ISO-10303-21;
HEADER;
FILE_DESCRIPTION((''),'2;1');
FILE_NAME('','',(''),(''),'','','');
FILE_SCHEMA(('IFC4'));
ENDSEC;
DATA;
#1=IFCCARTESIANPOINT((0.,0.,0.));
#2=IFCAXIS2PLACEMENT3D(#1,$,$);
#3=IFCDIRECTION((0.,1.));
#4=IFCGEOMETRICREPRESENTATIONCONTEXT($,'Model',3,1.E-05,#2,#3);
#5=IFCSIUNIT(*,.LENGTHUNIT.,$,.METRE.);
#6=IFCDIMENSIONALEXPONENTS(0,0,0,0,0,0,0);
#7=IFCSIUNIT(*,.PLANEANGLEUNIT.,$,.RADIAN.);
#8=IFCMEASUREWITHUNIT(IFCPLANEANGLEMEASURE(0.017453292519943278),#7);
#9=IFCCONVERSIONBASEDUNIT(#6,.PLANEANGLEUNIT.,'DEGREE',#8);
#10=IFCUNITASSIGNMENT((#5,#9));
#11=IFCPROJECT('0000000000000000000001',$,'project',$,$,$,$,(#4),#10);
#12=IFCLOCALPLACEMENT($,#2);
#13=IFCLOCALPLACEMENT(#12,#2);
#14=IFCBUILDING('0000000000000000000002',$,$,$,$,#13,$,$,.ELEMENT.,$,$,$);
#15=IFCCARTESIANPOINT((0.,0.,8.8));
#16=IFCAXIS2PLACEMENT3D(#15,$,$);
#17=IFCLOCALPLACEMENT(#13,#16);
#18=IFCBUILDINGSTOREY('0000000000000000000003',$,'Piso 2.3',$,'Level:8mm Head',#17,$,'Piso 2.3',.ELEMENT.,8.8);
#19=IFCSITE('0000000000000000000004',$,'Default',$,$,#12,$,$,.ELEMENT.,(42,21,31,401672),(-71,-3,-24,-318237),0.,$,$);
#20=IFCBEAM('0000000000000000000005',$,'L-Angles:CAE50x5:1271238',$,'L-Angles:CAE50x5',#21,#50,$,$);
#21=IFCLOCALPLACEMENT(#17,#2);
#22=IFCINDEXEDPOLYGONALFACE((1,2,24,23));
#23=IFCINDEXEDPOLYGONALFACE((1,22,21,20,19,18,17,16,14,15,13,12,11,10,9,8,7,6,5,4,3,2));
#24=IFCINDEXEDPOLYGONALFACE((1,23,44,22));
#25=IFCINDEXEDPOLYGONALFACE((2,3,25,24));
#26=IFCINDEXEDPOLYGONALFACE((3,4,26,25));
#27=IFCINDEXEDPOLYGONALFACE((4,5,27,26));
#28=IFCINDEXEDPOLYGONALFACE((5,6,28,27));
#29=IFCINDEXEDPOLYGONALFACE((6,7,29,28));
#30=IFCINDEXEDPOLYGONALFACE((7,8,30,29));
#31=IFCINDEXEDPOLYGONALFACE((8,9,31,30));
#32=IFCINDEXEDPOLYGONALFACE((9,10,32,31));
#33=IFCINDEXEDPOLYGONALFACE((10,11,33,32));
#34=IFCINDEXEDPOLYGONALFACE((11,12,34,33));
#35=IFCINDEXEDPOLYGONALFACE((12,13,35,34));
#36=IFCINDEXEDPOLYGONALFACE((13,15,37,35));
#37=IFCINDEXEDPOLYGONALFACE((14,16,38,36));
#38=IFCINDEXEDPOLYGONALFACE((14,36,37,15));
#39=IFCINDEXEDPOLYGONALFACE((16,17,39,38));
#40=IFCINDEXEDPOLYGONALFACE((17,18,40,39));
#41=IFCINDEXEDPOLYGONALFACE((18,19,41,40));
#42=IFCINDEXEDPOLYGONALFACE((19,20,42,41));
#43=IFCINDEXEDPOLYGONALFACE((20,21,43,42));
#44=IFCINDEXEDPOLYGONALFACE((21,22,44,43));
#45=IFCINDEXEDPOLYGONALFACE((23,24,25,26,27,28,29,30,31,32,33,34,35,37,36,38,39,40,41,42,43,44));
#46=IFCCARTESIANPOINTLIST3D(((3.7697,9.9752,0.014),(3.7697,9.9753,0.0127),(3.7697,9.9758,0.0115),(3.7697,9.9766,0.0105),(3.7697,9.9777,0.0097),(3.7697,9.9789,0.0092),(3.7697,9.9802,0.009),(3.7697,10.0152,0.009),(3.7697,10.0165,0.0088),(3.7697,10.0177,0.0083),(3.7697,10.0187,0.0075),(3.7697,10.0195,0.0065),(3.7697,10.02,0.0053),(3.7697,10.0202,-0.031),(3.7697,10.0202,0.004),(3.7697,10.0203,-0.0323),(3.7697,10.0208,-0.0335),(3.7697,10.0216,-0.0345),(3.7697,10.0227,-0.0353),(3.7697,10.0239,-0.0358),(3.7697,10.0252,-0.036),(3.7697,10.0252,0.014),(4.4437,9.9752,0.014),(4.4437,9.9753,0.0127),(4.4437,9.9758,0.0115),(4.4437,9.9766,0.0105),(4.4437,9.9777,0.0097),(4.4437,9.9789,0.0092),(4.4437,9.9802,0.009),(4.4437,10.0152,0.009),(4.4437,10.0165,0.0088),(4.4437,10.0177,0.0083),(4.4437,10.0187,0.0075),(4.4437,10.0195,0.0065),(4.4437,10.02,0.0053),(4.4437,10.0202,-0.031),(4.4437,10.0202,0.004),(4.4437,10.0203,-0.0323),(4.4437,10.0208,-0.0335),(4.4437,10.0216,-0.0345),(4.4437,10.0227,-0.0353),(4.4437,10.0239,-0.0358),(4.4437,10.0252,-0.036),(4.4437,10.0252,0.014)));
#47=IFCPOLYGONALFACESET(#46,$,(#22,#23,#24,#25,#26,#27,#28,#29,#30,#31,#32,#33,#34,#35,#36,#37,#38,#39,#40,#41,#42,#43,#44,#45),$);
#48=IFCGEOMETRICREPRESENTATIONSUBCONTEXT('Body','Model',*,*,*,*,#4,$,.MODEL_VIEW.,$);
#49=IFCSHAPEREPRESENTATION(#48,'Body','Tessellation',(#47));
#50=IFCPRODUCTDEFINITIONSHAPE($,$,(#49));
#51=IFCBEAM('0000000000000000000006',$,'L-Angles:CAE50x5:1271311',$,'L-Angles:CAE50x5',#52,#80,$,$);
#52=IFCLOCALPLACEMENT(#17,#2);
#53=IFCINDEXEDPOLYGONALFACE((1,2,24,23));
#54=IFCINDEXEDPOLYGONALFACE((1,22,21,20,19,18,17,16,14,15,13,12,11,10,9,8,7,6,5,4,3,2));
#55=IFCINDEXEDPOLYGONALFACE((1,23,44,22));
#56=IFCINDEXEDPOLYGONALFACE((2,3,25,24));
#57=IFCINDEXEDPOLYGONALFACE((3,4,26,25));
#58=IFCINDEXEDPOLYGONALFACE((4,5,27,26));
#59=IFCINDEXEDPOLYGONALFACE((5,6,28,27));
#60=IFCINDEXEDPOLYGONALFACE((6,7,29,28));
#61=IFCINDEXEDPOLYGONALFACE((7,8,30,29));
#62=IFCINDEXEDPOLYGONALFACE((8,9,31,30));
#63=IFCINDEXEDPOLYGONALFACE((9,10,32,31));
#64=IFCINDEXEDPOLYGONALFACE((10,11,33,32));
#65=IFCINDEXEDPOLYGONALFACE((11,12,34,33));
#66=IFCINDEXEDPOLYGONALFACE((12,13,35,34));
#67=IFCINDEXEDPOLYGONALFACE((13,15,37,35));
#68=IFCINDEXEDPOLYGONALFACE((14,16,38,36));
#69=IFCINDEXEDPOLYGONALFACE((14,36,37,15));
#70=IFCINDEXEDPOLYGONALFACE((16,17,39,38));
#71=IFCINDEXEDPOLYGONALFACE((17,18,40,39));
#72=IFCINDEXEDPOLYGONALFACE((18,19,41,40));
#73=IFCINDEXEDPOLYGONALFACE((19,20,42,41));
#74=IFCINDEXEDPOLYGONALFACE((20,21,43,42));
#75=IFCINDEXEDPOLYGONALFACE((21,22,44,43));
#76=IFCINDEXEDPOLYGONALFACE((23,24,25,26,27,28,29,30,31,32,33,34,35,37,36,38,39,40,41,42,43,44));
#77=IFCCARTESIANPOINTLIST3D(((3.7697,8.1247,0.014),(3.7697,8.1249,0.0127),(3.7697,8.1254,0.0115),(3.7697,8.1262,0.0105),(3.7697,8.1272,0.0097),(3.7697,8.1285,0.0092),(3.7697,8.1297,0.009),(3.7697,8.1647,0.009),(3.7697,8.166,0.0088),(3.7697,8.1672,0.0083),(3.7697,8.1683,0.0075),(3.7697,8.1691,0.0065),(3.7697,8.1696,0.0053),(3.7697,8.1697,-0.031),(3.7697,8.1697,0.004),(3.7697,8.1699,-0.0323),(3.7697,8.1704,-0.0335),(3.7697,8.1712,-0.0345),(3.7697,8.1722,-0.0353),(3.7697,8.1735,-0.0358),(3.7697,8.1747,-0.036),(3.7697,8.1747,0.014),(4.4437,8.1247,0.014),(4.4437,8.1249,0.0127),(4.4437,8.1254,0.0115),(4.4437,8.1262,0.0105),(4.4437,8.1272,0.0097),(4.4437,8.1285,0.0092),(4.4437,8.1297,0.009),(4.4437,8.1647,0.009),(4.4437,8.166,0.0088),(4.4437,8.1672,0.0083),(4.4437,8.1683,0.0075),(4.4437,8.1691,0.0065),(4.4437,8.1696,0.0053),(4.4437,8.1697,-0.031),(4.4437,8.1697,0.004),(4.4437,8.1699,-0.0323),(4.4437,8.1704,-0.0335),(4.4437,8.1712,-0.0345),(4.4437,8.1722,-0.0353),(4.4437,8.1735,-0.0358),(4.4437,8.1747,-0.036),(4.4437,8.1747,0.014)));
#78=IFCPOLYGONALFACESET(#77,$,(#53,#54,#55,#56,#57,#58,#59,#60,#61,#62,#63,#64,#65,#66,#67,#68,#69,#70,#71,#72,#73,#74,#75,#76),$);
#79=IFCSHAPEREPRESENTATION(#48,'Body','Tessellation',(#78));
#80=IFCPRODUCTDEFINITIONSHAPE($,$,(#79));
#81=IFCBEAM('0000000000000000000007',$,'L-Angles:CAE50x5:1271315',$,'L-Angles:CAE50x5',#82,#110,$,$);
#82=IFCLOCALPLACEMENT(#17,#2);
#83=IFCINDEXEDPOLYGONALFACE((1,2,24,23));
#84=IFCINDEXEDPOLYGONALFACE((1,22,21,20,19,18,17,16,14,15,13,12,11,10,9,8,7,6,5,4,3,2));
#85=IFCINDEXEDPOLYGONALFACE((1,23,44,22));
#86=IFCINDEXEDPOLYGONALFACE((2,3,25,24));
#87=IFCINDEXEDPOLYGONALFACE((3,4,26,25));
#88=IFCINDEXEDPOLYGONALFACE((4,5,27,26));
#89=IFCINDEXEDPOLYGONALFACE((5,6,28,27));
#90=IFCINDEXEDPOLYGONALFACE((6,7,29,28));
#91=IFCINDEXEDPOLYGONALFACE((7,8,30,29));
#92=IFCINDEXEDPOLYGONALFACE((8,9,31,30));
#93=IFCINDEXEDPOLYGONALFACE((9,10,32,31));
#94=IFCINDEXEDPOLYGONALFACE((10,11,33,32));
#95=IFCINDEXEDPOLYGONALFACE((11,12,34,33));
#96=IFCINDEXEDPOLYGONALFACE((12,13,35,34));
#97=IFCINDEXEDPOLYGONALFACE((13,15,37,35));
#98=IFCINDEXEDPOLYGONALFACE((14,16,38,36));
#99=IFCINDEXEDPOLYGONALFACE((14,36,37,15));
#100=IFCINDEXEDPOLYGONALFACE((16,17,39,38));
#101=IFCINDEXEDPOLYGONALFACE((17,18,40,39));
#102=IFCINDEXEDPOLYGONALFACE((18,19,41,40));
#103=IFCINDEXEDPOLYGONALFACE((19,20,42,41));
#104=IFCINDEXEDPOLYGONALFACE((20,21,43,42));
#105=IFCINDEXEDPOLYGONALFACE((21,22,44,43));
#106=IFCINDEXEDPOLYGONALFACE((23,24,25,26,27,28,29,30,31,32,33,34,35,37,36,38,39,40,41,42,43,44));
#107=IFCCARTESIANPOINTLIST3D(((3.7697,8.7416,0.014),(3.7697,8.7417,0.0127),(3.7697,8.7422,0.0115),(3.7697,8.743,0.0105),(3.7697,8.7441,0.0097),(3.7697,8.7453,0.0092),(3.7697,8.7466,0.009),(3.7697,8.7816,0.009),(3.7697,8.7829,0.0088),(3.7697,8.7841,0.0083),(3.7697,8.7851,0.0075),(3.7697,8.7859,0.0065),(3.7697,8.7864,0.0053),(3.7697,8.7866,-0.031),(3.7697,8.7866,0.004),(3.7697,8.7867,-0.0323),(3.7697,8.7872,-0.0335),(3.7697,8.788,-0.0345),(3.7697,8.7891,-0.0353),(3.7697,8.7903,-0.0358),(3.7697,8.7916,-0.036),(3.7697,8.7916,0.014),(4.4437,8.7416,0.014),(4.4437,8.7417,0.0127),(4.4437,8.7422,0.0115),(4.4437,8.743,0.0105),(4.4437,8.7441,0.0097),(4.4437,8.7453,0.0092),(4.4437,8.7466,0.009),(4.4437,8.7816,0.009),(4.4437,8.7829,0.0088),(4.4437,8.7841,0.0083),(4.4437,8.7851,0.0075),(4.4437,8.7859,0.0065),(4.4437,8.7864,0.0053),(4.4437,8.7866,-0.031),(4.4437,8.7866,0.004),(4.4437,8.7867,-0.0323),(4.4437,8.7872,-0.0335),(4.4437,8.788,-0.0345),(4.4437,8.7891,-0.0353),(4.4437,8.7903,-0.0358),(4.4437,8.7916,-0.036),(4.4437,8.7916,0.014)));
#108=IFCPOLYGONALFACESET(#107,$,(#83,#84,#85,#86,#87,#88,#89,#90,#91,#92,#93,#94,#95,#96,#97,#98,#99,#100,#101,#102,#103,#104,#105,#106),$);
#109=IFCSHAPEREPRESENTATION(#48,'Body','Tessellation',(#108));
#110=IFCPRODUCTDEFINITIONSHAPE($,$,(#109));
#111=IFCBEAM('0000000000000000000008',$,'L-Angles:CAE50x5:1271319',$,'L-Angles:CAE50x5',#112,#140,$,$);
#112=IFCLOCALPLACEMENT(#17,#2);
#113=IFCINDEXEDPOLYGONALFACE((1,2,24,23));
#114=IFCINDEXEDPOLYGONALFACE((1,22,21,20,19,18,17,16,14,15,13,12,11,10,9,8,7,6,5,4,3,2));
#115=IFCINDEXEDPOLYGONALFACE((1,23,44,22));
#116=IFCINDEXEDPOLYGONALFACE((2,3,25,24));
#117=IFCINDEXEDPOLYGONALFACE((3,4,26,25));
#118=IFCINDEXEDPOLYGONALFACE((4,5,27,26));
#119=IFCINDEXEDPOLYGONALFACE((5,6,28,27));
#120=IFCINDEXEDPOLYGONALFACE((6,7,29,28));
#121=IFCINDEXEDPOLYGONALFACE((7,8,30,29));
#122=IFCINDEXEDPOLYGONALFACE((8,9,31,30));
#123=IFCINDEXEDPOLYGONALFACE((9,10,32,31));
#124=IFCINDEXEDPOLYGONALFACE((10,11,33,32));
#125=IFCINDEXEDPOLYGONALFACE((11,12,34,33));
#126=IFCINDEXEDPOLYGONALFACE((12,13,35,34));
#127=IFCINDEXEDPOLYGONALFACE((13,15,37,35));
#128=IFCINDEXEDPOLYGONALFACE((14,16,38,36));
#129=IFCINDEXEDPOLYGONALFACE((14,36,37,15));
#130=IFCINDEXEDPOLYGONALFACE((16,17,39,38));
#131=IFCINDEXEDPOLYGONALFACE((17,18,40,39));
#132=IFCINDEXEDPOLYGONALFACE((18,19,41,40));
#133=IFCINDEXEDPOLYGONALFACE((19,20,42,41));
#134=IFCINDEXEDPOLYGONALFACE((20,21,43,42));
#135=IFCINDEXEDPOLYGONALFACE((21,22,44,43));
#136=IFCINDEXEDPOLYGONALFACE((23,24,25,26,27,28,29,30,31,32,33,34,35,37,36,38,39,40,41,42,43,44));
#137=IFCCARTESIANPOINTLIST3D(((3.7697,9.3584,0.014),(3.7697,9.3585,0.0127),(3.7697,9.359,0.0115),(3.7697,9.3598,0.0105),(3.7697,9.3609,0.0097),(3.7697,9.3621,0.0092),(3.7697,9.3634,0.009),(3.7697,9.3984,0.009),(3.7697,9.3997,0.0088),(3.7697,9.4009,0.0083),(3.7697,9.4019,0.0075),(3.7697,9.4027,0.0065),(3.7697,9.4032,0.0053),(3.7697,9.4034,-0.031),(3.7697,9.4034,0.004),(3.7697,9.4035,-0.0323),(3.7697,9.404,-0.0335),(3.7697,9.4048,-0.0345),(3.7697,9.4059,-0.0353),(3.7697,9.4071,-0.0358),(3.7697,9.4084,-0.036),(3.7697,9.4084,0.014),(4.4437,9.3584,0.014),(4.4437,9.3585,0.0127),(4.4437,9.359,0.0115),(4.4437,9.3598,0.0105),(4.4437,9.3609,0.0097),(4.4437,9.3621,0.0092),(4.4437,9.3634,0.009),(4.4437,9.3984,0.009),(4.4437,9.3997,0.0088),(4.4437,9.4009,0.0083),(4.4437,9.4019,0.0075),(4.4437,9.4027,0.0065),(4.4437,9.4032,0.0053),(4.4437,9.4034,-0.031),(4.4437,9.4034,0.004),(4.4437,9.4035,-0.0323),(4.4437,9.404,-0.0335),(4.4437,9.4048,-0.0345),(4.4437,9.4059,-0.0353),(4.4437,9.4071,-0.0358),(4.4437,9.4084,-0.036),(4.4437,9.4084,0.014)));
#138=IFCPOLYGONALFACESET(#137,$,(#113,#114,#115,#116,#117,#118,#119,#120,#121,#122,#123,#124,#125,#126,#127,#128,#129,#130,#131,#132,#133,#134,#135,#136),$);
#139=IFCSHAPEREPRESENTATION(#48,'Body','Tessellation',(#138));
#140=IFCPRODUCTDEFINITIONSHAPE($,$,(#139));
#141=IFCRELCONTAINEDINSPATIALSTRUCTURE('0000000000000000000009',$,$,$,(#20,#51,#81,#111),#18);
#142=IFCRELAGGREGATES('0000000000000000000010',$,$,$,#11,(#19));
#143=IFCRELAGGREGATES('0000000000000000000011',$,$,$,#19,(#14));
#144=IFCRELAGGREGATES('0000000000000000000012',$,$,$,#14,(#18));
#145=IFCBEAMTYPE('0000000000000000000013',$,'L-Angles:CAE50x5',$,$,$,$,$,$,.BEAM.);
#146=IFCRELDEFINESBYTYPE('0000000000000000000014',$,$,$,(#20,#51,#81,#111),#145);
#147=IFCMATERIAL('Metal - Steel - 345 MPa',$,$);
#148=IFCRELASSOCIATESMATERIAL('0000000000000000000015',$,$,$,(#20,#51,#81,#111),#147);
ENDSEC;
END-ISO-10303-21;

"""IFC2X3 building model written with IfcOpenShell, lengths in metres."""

from ifc_helpers import new_model, entity, si_unit, converted_unit, direction, frame, frame_2d, origin, place, context, subcontext, project, spatial, polyline, circle_curve, parameter, trimmed, segment, composite_curve, outline, extrude, material, type_object, element, save


model = new_model("IFC2X3")

# Units and contexts
model_context = context("Model", 3, precision=1e-05, world=origin(), true_north=direction((0.0, 1.0)))
body_context = subcontext(model_context, "Body", "Model", "MODEL_VIEW")
ifc_project = project(units=[si_unit("LENGTHUNIT", "METRE"), converted_unit("PLANEANGLEUNIT", "DEGREE", entity("IfcPlaneAngleMeasure", 0.017453292519943278), si_unit("PLANEANGLEUNIT", "RADIAN"), dimensions=[0, 0, 0, 0, 0, 0, 0])], contexts=[model_context])

# Site, building, storey
site_placement = place(None, origin())
site = spatial("IfcSite", under=ifc_project, at=site_placement, Name="Default", CompositionType="ELEMENT", RefLatitude=(42, 21, 31, 401672), RefLongitude=(-71, -3, -24, -318237), RefElevation=0.0)
building_placement = place(site_placement, origin())
building = spatial("IfcBuilding", under=site, at=building_placement, CompositionType="ELEMENT")
storey_placement = place(building_placement, frame((0.0, 0.0, 8.8)))
storey = spatial("IfcBuildingStorey", under=building, at=storey_placement, Name="Piso 2.3", ObjectType="Level:8mm Head", LongName="Piso 2.3", CompositionType="ELEMENT", Elevation=8.8)

# Shared definitions
ifc_material_1 = material(Name="Metal - Steel - 345 MPa")

# Beams
beam_type_1 = type_object("IfcBeamType", Name="L-Angles:CAE50x5", PredefinedType="BEAM")
beam_1_placement = place(storey_placement, frame((3.7067, 10.0112, 0.0)))
element("IfcBeam", 1, at=beam_1_placement, inside=storey, type_object=beam_type_1, material=ifc_material_1, Name="L-Angles:CAE50x5:1271238", ObjectType="L-Angles:CAE50x5", context=body_context, shape_type="SweptSolid", body=[
    extrude(outline(composite_curve([segment(polyline([(-0.0336, -0.0164), (0.0164, -0.0164)]), True, "CONTINUOUS"), segment(polyline([(0.0164, -0.0164), (0.0164, 0.0336)]), True, "CONTINUOUS"), segment(trimmed(circle_curve(frame_2d((0.0164, 0.0286), x_axis=(0.0, 1.0)), 0.005), [parameter(0.0)], [parameter(90.0)], True, "PARAMETER"), True, "CONTINUOUS"), segment(polyline([(0.0114, 0.0286), (0.0114, -0.0064)]), True, "CONTINUOUS"), segment(trimmed(circle_curve(frame_2d((0.0064, -0.0064), x_axis=(1.0, 0.0)), 0.005), [parameter(270.0)], [parameter(0.0)], True, "PARAMETER"), False, "CONTINUOUS"), segment(polyline([(0.0064, -0.0114), (-0.0286, -0.0114)]), True, "CONTINUOUS"), segment(trimmed(circle_curve(frame_2d((-0.0286, -0.0164), x_axis=(0.0, 1.0)), 0.005), [parameter(0.0)], [parameter(90.0)], True, "PARAMETER"), True, "CONTINUOUS")], self_intersect=False)), frame((0.063, -0.0024, -0.0024), z_axis=(1.0, 0.0, 0.0), x_axis=(0.0, 0.0, 1.0)), (0.0, 0.0, 1.0), 0.674),
])
beam_2_placement = place(storey_placement, frame((3.7067, 8.1607, 0.0)))
element("IfcBeam", 2, at=beam_2_placement, inside=storey, type_object=beam_type_1, material=ifc_material_1, Name="L-Angles:CAE50x5:1271311", ObjectType="L-Angles:CAE50x5", context=body_context, shape_type="SweptSolid", body=[
    extrude(outline(composite_curve([segment(polyline([(-0.0336, -0.0164), (0.0164, -0.0164)]), True, "CONTINUOUS"), segment(polyline([(0.0164, -0.0164), (0.0164, 0.0336)]), True, "CONTINUOUS"), segment(trimmed(circle_curve(frame_2d((0.0164, 0.0286), x_axis=(0.0, 1.0)), 0.005), [parameter(0.0)], [parameter(90.0)], True, "PARAMETER"), True, "CONTINUOUS"), segment(polyline([(0.0114, 0.0286), (0.0114, -0.0064)]), True, "CONTINUOUS"), segment(trimmed(circle_curve(frame_2d((0.0064, -0.0064), x_axis=(1.0, 0.0)), 0.005), [parameter(270.0)], [parameter(0.0)], True, "PARAMETER"), False, "CONTINUOUS"), segment(polyline([(0.0064, -0.0114), (-0.0286, -0.0114)]), True, "CONTINUOUS"), segment(trimmed(circle_curve(frame_2d((-0.0286, -0.0164), x_axis=(0.0, 1.0)), 0.005), [parameter(0.0)], [parameter(90.0)], True, "PARAMETER"), True, "CONTINUOUS")], self_intersect=False)), frame((0.063, -0.0024, -0.0024), z_axis=(1.0, 0.0, 0.0), x_axis=(0.0, 0.0, 1.0)), (0.0, 0.0, 1.0), 0.674),
])
beam_3_placement = place(storey_placement, frame((3.7067, 8.7776, 0.0)))
element("IfcBeam", 3, at=beam_3_placement, inside=storey, type_object=beam_type_1, material=ifc_material_1, Name="L-Angles:CAE50x5:1271315", ObjectType="L-Angles:CAE50x5", context=body_context, shape_type="SweptSolid", body=[
    extrude(outline(composite_curve([segment(polyline([(-0.0336, -0.0164), (0.0164, -0.0164)]), True, "CONTINUOUS"), segment(polyline([(0.0164, -0.0164), (0.0164, 0.0336)]), True, "CONTINUOUS"), segment(trimmed(circle_curve(frame_2d((0.0164, 0.0286), x_axis=(0.0, 1.0)), 0.005), [parameter(0.0)], [parameter(90.0)], True, "PARAMETER"), True, "CONTINUOUS"), segment(polyline([(0.0114, 0.0286), (0.0114, -0.0064)]), True, "CONTINUOUS"), segment(trimmed(circle_curve(frame_2d((0.0064, -0.0064), x_axis=(1.0, 0.0)), 0.005), [parameter(270.0)], [parameter(0.0)], True, "PARAMETER"), False, "CONTINUOUS"), segment(polyline([(0.0064, -0.0114), (-0.0286, -0.0114)]), True, "CONTINUOUS"), segment(trimmed(circle_curve(frame_2d((-0.0286, -0.0164), x_axis=(0.0, 1.0)), 0.005), [parameter(0.0)], [parameter(90.0)], True, "PARAMETER"), True, "CONTINUOUS")], self_intersect=False)), frame((0.063, -0.0024, -0.0024), z_axis=(1.0, 0.0, 0.0), x_axis=(0.0, 0.0, 1.0)), (0.0, 0.0, 1.0), 0.674),
])
beam_4_placement = place(storey_placement, frame((3.7067, 9.3944, 0.0)))
element("IfcBeam", 4, at=beam_4_placement, inside=storey, type_object=beam_type_1, material=ifc_material_1, Name="L-Angles:CAE50x5:1271319", ObjectType="L-Angles:CAE50x5", context=body_context, shape_type="SweptSolid", body=[
    extrude(outline(composite_curve([segment(polyline([(-0.0336, -0.0164), (0.0164, -0.0164)]), True, "CONTINUOUS"), segment(polyline([(0.0164, -0.0164), (0.0164, 0.0336)]), True, "CONTINUOUS"), segment(trimmed(circle_curve(frame_2d((0.0164, 0.0286), x_axis=(0.0, 1.0)), 0.005), [parameter(0.0)], [parameter(90.0)], True, "PARAMETER"), True, "CONTINUOUS"), segment(polyline([(0.0114, 0.0286), (0.0114, -0.0064)]), True, "CONTINUOUS"), segment(trimmed(circle_curve(frame_2d((0.0064, -0.0064), x_axis=(1.0, 0.0)), 0.005), [parameter(270.0)], [parameter(0.0)], True, "PARAMETER"), False, "CONTINUOUS"), segment(polyline([(0.0064, -0.0114), (-0.0286, -0.0114)]), True, "CONTINUOUS"), segment(trimmed(circle_curve(frame_2d((-0.0286, -0.0164), x_axis=(0.0, 1.0)), 0.005), [parameter(0.0)], [parameter(90.0)], True, "PARAMETER"), True, "CONTINUOUS")], self_intersect=False)), frame((0.063, -0.0024, -0.0024), z_axis=(1.0, 0.0, 0.0), x_axis=(0.0, 0.0, 1.0)), (0.0, 0.0, 1.0), 0.674),
])

save(model, "model.ifc")
